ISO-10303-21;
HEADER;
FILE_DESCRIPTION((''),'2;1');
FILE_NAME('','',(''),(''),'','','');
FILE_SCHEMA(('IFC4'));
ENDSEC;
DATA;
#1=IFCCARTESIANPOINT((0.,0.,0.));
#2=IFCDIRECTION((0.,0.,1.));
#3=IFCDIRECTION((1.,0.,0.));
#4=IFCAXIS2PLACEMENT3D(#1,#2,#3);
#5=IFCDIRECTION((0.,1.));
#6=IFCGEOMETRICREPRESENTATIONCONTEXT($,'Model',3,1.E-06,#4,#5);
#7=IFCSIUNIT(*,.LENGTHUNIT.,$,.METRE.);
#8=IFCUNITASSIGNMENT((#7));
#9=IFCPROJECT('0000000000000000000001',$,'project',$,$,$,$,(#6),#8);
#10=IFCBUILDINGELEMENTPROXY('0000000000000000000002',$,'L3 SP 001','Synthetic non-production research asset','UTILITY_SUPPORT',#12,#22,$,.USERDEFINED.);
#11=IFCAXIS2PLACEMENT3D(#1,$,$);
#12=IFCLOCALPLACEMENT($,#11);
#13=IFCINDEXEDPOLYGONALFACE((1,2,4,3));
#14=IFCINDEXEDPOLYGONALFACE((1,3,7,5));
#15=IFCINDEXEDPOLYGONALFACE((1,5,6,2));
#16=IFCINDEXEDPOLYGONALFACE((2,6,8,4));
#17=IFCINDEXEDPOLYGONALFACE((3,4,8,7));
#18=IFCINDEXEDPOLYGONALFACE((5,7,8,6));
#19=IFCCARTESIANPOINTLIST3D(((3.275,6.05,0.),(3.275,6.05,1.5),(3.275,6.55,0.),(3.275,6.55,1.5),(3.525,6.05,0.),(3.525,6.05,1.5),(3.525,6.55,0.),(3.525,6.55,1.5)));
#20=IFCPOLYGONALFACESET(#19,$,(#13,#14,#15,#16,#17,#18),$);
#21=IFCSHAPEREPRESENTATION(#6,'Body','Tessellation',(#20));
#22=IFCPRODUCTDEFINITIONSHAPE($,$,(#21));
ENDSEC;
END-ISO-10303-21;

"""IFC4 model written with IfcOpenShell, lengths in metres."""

from ifc_helpers import new_model, si_unit, direction, frame, origin_with_axes, origin_2d_with_axis, place, context, project, rectangle, extrude, element, save


model = new_model("IFC4")

# Units and contexts
model_context = context("Model", 3, precision=1e-06, world=origin_with_axes(), true_north=direction((0.0, 1.0)))
ifc_project = project(units=[si_unit("LENGTHUNIT", "METRE")], contexts=[model_context])

# Building element proxy
proxy_placement = place(None, frame((3.4, 6.3, 0.0), z_axis=(0.0, 0.0, 1.0), x_axis=(1.0, 0.0, 0.0)))
element("IfcBuildingElementProxy", 1, at=proxy_placement, Name="L3 SP 001", Description="Synthetic non-production research asset", ObjectType="UTILITY_SUPPORT", PredefinedType="USERDEFINED", context=model_context, shape_type="SweptSolid", body=[
    extrude(rectangle(XDim=0.25, YDim=0.5, at=origin_2d_with_axis()), origin_with_axes(), (0.0, 0.0, 1.0), 1.5),
])

save(model, "model.ifc")
